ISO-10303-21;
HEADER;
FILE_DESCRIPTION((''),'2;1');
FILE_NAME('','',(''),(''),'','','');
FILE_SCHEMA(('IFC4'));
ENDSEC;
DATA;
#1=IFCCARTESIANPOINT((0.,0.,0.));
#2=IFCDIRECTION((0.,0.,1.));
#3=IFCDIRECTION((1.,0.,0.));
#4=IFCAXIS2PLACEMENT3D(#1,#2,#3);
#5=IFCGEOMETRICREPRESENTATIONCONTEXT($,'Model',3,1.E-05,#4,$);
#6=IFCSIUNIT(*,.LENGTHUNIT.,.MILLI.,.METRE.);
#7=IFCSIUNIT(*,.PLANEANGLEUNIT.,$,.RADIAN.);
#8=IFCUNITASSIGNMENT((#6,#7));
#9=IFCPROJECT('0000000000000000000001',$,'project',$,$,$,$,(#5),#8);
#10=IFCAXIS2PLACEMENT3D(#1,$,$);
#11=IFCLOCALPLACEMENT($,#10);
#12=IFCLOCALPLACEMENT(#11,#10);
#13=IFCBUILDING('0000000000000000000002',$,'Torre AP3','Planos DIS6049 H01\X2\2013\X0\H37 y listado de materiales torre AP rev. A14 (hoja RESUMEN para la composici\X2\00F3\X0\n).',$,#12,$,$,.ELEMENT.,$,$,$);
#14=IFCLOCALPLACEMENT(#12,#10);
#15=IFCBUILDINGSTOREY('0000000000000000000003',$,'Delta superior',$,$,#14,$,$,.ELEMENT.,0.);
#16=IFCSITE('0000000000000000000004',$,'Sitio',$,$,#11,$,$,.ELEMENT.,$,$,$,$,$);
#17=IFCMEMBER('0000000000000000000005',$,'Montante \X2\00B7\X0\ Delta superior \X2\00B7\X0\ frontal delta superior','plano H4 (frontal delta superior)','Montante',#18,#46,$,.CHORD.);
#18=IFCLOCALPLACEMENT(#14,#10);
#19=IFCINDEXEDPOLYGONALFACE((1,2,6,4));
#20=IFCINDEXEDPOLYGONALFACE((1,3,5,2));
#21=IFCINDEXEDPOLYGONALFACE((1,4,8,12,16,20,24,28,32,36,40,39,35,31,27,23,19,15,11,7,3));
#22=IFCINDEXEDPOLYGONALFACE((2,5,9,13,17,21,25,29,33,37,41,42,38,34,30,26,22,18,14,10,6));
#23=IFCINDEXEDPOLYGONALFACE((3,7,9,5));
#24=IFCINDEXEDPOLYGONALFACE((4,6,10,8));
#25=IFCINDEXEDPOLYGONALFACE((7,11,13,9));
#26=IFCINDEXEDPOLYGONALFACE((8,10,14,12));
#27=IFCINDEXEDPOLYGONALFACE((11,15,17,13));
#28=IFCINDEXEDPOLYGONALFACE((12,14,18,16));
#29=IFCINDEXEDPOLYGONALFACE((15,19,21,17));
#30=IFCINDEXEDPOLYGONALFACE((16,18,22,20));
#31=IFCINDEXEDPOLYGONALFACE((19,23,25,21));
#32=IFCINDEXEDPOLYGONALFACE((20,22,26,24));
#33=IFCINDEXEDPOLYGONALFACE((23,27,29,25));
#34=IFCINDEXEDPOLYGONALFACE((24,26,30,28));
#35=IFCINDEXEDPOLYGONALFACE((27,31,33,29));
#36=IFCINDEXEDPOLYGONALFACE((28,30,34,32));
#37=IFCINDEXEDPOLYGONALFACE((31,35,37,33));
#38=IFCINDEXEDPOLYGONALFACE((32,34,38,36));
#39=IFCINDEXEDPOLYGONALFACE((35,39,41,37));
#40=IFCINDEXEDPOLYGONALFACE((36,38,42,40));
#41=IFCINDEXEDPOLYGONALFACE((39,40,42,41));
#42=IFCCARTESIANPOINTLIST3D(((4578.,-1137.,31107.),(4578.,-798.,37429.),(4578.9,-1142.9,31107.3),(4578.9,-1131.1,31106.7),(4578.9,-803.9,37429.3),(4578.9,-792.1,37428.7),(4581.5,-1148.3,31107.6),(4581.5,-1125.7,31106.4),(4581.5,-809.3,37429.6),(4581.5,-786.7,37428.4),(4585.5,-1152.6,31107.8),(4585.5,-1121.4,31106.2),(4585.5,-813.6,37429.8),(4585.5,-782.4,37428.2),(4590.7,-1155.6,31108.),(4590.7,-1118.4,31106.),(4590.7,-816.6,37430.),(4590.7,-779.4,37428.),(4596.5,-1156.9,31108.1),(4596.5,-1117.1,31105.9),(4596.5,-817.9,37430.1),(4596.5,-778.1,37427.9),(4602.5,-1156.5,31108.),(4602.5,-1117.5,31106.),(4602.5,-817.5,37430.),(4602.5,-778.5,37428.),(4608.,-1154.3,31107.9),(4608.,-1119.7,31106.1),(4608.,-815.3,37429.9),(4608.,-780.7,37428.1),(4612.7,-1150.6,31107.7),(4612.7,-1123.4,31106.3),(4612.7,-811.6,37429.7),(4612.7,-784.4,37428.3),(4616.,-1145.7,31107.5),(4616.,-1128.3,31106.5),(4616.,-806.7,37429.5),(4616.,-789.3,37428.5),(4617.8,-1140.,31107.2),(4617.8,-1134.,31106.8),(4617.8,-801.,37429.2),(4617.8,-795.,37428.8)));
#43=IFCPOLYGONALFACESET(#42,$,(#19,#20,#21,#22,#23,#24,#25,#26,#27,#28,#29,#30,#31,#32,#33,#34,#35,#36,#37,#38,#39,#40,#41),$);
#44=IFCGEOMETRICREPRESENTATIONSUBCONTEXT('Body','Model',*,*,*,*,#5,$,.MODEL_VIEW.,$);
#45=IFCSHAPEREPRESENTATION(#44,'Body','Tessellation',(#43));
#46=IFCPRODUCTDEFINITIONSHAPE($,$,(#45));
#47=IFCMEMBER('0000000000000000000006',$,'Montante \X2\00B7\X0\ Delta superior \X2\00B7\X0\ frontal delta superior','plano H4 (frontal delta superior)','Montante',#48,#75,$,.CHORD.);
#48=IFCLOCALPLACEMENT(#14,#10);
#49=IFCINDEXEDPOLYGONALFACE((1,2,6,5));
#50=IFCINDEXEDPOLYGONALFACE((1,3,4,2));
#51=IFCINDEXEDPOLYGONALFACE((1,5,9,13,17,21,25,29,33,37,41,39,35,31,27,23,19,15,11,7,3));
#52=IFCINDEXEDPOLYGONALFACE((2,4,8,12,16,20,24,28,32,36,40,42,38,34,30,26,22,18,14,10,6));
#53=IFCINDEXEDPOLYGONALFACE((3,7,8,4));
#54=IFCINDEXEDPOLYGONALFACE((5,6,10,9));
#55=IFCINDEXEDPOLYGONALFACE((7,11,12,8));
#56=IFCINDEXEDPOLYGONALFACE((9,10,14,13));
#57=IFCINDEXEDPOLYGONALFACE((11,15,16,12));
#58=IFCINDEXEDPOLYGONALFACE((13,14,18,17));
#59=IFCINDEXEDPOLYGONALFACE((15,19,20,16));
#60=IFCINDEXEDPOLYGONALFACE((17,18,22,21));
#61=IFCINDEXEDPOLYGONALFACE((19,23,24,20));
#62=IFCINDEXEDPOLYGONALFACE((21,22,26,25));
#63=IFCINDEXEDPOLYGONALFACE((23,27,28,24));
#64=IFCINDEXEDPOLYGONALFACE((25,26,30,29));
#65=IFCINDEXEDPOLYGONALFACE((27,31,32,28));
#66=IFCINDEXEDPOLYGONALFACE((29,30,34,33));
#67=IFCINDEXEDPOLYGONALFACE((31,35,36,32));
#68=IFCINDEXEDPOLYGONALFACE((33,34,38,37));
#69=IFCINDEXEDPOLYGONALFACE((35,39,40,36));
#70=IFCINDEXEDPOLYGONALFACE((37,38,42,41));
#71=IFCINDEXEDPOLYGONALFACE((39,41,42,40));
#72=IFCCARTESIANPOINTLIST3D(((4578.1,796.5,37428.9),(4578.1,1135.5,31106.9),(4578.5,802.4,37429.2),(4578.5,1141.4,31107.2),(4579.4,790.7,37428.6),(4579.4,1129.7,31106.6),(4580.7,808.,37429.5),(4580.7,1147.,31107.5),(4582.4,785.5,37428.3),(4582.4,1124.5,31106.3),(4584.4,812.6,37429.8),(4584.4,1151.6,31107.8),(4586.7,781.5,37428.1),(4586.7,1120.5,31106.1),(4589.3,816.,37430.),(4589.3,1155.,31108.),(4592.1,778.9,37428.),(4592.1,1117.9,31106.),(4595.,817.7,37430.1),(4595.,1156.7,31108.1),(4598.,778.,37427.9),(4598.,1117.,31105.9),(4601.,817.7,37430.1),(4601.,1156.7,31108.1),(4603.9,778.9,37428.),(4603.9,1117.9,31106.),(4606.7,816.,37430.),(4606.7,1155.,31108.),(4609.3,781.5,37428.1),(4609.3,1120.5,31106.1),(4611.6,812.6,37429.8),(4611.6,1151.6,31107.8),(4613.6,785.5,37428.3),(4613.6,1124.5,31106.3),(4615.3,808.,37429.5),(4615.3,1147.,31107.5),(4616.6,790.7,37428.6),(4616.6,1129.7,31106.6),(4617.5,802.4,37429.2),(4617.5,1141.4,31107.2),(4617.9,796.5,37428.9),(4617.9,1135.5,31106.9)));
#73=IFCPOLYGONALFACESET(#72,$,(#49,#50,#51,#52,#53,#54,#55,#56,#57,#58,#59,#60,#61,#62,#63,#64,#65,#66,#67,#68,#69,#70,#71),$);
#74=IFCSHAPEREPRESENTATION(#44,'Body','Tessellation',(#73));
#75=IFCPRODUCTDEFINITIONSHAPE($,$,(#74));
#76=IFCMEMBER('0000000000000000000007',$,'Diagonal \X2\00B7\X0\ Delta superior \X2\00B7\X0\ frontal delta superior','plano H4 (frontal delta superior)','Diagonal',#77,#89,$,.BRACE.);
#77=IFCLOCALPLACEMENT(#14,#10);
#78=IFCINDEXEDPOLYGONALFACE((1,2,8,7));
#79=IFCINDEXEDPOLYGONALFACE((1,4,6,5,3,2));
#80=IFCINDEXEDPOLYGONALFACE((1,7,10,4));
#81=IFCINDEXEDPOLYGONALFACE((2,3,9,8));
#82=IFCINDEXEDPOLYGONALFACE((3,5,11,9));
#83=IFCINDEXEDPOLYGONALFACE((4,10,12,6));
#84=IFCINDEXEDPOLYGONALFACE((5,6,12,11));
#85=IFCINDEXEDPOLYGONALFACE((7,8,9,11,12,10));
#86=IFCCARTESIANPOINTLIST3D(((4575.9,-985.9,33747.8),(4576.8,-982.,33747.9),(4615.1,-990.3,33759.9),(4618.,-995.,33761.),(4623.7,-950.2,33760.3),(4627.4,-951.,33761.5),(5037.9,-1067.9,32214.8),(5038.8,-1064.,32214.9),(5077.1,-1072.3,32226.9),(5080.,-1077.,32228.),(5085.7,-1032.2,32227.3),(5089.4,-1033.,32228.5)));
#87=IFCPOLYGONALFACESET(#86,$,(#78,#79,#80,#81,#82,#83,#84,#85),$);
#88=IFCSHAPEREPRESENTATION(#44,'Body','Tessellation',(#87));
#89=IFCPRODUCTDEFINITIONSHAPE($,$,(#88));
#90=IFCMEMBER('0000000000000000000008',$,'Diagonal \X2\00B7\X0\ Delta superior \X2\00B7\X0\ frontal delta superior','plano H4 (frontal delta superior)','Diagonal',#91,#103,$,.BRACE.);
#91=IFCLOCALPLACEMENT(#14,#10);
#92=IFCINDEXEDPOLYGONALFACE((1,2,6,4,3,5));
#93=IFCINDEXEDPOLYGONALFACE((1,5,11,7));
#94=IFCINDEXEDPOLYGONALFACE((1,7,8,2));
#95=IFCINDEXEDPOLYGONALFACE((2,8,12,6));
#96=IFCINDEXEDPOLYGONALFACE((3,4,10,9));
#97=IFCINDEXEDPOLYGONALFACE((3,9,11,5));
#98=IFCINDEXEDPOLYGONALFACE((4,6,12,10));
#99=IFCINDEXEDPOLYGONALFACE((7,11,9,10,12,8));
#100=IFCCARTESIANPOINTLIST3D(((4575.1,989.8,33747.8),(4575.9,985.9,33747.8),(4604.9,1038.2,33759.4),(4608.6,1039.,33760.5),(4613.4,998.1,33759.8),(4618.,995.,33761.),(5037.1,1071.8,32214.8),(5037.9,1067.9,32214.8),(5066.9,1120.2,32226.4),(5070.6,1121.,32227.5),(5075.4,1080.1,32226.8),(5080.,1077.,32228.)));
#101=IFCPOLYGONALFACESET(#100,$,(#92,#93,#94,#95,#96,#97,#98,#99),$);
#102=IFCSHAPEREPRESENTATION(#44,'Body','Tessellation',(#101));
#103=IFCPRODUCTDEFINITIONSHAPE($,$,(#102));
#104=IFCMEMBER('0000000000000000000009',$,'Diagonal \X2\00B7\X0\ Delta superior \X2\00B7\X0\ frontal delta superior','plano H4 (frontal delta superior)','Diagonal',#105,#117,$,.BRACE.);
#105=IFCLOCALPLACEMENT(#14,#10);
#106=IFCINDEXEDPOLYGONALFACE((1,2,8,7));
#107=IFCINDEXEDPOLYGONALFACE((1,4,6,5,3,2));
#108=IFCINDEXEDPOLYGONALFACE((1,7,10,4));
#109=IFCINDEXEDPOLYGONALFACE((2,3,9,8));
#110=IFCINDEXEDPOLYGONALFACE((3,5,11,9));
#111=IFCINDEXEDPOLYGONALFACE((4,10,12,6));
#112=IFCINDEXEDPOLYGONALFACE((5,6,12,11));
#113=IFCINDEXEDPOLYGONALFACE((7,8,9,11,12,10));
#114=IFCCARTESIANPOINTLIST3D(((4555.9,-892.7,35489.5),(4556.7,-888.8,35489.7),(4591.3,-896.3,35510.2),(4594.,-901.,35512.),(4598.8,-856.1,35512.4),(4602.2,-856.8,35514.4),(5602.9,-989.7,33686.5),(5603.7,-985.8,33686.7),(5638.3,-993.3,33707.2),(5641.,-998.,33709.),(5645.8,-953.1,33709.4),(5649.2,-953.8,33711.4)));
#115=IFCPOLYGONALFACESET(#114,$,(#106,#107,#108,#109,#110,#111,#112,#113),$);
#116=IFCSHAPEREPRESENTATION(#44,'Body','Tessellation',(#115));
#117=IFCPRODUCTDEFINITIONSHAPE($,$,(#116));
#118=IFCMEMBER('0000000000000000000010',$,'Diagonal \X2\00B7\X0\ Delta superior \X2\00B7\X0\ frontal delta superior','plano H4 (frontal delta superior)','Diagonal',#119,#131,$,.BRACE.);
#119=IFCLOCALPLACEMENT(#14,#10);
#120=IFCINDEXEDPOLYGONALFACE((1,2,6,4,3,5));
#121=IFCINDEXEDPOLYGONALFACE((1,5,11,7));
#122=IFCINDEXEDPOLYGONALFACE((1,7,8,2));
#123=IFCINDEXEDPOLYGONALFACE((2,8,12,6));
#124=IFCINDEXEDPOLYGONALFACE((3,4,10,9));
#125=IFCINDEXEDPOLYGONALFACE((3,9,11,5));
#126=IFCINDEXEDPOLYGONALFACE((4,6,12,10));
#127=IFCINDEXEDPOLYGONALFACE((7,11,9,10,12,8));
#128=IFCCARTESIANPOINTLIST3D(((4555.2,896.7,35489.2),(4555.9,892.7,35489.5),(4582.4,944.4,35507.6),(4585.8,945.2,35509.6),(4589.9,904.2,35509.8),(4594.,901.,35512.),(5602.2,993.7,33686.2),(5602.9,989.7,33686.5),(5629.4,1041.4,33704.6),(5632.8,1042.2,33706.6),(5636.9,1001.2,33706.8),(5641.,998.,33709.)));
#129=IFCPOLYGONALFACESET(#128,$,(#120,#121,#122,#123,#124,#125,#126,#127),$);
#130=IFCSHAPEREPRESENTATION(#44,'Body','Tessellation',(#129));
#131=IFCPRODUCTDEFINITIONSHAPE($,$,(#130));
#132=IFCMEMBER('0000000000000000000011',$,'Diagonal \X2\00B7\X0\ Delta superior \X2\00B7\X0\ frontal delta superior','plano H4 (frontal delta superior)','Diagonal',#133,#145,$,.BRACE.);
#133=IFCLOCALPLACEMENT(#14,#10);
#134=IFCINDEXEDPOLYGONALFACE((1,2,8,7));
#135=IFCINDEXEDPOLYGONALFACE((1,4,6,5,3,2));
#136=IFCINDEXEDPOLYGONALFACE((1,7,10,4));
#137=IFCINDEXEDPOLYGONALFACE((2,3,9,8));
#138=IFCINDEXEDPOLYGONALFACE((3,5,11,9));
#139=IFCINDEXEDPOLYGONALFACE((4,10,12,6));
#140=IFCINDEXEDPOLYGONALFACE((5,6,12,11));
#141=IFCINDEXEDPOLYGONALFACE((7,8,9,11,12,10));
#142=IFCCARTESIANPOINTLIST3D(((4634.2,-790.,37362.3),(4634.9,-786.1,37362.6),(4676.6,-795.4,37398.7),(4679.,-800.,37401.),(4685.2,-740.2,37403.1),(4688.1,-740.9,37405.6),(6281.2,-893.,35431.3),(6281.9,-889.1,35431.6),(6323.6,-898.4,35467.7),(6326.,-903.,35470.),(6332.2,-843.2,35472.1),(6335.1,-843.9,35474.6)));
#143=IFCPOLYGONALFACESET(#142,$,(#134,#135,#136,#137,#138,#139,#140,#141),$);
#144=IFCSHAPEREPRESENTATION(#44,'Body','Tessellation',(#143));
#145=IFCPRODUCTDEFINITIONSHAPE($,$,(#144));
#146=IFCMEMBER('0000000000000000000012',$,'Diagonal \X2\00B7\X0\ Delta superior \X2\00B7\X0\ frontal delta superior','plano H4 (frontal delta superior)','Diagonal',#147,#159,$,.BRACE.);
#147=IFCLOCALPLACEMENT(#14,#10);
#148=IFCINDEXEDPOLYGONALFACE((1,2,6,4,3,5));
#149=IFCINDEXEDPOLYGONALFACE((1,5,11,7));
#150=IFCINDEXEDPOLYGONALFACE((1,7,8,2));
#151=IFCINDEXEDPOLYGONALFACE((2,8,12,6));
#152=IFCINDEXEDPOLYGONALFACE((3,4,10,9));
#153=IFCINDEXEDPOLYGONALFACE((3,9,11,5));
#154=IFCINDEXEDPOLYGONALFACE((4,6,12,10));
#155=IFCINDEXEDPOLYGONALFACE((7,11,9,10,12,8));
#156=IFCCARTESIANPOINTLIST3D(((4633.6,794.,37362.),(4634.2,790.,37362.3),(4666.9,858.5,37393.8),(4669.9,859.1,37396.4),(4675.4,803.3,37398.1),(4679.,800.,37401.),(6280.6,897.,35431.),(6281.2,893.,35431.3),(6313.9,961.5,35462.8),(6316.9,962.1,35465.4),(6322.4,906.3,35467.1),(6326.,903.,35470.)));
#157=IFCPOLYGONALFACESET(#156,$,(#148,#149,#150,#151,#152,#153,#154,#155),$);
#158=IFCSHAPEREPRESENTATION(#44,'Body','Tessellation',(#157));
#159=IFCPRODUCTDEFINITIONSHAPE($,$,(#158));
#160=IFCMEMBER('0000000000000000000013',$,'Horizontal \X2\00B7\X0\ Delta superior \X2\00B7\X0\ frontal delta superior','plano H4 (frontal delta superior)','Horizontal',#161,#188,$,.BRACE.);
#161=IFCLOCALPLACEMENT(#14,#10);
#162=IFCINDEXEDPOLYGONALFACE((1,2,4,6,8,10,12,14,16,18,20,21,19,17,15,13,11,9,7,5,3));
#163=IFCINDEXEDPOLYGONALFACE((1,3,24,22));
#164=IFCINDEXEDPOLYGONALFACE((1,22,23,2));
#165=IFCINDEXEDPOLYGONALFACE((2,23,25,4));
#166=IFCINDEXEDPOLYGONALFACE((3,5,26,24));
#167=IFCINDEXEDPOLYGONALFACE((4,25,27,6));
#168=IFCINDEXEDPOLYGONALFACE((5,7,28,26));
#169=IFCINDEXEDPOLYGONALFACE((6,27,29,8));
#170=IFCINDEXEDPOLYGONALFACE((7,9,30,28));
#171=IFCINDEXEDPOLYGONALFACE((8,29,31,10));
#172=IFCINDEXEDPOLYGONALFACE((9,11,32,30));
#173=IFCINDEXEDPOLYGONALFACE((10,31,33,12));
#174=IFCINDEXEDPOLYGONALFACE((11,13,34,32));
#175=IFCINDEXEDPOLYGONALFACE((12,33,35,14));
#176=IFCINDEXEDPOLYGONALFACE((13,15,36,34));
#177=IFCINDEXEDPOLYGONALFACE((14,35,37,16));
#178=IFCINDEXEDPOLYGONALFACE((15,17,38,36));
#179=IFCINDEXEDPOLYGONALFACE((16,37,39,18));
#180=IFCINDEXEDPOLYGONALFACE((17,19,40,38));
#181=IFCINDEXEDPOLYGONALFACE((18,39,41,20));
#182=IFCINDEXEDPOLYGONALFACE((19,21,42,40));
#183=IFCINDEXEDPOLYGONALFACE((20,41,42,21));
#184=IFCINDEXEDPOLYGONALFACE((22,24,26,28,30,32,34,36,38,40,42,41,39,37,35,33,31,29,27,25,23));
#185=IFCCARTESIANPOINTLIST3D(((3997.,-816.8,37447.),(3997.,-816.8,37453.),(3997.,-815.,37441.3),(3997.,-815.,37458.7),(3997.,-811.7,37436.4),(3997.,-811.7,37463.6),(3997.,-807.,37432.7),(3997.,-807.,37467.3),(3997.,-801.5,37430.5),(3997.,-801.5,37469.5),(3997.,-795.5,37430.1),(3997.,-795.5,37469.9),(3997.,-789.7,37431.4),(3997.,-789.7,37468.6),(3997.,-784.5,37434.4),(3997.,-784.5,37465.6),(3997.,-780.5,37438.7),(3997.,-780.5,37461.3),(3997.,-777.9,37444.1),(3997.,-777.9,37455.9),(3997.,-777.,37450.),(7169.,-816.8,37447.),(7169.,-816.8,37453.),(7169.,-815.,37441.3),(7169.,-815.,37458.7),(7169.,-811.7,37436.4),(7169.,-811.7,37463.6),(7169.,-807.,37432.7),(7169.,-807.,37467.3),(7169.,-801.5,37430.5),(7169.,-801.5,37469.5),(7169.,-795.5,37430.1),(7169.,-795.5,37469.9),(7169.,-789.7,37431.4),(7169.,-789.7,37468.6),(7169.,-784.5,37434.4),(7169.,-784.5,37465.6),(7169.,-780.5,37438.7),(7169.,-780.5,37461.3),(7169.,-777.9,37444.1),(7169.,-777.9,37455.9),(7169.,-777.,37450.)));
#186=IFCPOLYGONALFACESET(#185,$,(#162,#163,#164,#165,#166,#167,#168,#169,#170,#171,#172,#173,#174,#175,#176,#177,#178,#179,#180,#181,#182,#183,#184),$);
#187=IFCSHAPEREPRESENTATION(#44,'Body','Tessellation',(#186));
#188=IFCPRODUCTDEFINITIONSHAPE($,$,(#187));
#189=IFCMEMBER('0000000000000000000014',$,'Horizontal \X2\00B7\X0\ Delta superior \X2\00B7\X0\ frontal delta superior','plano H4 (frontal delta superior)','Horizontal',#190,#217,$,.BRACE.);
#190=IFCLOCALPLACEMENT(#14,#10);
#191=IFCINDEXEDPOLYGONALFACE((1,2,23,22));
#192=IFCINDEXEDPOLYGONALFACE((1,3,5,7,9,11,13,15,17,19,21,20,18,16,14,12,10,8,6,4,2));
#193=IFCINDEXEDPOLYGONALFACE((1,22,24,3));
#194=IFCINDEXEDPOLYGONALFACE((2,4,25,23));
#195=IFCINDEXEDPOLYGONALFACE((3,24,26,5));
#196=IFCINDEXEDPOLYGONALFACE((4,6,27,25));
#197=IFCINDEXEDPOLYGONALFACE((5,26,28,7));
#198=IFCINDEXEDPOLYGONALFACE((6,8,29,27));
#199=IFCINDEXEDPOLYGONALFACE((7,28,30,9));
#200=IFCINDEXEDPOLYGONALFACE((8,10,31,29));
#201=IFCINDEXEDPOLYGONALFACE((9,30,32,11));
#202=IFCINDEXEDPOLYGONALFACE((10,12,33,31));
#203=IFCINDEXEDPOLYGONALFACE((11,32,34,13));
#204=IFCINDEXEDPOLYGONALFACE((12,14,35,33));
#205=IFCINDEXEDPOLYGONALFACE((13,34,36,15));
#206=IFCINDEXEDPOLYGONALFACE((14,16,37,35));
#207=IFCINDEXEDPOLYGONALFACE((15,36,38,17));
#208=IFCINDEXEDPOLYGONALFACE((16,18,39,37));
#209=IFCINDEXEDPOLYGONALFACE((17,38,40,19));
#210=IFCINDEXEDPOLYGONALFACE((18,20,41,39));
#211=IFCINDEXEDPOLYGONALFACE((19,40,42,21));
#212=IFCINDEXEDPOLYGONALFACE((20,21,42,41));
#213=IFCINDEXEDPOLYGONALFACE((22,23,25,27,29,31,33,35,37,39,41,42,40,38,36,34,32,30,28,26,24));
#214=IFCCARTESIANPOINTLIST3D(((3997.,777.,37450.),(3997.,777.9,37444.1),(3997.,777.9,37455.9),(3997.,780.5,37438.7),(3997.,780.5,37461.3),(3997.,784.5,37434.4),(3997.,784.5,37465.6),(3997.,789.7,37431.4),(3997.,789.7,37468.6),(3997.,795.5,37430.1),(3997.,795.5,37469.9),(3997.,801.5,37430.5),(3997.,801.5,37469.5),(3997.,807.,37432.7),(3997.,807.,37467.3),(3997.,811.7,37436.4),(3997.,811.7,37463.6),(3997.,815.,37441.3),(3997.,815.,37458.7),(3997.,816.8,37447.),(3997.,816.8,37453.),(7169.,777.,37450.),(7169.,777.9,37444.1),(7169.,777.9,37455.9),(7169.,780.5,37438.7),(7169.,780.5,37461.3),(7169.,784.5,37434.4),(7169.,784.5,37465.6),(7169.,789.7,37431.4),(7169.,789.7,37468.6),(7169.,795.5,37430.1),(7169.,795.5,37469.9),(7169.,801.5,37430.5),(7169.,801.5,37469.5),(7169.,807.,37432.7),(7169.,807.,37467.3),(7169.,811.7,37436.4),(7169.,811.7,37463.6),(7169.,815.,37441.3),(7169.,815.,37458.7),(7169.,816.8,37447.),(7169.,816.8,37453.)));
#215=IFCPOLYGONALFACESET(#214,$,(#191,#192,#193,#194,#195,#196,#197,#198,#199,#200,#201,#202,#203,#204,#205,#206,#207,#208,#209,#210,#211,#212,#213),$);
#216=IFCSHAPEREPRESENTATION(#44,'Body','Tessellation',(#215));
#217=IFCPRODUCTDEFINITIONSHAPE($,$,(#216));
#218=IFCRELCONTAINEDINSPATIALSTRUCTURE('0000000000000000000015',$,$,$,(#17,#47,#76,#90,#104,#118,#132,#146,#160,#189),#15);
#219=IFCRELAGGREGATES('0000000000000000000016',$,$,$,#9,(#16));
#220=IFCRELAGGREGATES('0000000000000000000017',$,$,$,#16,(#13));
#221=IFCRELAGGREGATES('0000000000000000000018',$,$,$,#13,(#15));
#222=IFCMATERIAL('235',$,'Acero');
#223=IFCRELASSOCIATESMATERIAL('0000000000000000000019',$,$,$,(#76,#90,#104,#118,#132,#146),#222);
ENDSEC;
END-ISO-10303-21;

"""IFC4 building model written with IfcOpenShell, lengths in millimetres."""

from ifc_helpers import new_model, si_unit, frame, frame_2d, origin, origin_with_axes, place, context, subcontext, project, spatial, circle, l_section, extrude, material, element, save


model = new_model("IFC4")

# Units and contexts
model_context = context("Model", 3, precision=1e-05, world=origin_with_axes())
body_context = subcontext(model_context, "Body", "Model", "MODEL_VIEW")
ifc_project = project(units=[si_unit("LENGTHUNIT", "METRE", prefix="MILLI"), si_unit("PLANEANGLEUNIT", "RADIAN")], contexts=[model_context])

# Site, building, storey
site_placement = place(None, origin())
site = spatial("IfcSite", under=ifc_project, at=site_placement, Name="Sitio", CompositionType="ELEMENT")
building_placement = place(site_placement, origin())
building = spatial("IfcBuilding", under=site, at=building_placement, Name="Torre AP3", Description="Planos DIS6049 H01–H37 y listado de materiales torre AP rev. A14 (hoja RESUMEN para la composición).", CompositionType="ELEMENT")
storey_placement = place(building_placement, origin())
storey = spatial("IfcBuildingStorey", under=building, at=storey_placement, Name="Delta superior", CompositionType="ELEMENT", Elevation=0.0)

# Members
for number, where, z_axis, x_axis, name in (
    (1, (4598.0, -798.0, 37429.0), (0.0, -0.053545, -0.998565), (-1.0, 0.0, 0.0), "Montante · Delta superior · frontal delta superior"),
    (2, (4598.0, 798.0, 37429.0), (0.0, 0.053545, -0.998565), (0.0, -0.998565, -0.053545), "Montante · Delta superior · frontal delta superior"),
):
    element("IfcMember", number, at=place(storey_placement, frame(where, z_axis=z_axis, x_axis=x_axis)), inside=storey, Name=name, Description="plano H4 (frontal delta superior)", ObjectType="Montante", PredefinedType="CHORD", context=body_context, shape_type="SweptSolid", body=[
        extrude(circle(Radius=20.0), None, (0.0, 0.0, 1.0), 6331.1),
    ])
ifc_material_1 = material(Name="235", Category="Acero")
for number, where, z_axis, x_axis, name in (
    (3, (4618.0, -995.0, 33761.0), (0.288173, -0.051148, -0.956211), (-0.934509, 0.202848, -0.292483), "Diagonal · Delta superior · frontal delta superior"),
    (4, (4618.0, 995.0, 33761.0), (0.288173, 0.051148, -0.956211), (-0.934509, -0.202848, -0.292483), "Diagonal · Delta superior · frontal delta superior"),
):
    element("IfcMember", number, at=place(storey_placement, frame(where, z_axis=z_axis, x_axis=x_axis)), inside=storey, material=ifc_material_1, Name=name, Description="plano H4 (frontal delta superior)", ObjectType="Diagonal", PredefinedType="BRACE", context=body_context, shape_type="SweptSolid", body=[
        extrude(l_section(Depth=45.0, Width=45.0, Thickness=4.0, at=frame_2d((22.5, 22.5))), None, (0.0, 0.0, 1.0), 1603.2),
    ])
for number, where, z_axis, x_axis, name in (
    (5, (4594.0, -901.0, 35512.0), (0.501628, -0.046474, -0.863834), (-0.845685, 0.183933, -0.500984), "Diagonal · Delta superior · frontal delta superior"),
    (6, (4594.0, 901.0, 35512.0), (0.501628, 0.046474, -0.863834), (-0.845685, -0.183933, -0.500984), "Diagonal · Delta superior · frontal delta superior"),
):
    element("IfcMember", number, at=place(storey_placement, frame(where, z_axis=z_axis, x_axis=x_axis)), inside=storey, material=ifc_material_1, Name=name, Description="plano H4 (frontal delta superior)", ObjectType="Diagonal", PredefinedType="BRACE", context=body_context, shape_type="SweptSolid", body=[
        extrude(l_section(Depth=45.0, Width=45.0, Thickness=4.0, at=frame_2d((22.5, 22.5))), None, (0.0, 0.0, 1.0), 2087.2),
    ])
for number, where, z_axis, x_axis, name in (
    (7, (4679.0, -800.0, 37401.0), (0.648406, -0.04055, -0.760214), (-0.745871, 0.166153, -0.645035), "Diagonal · Delta superior · frontal delta superior"),
    (8, (4679.0, 800.0, 37401.0), (0.648406, 0.04055, -0.760214), (-0.745871, -0.166153, -0.645035), "Diagonal · Delta superior · frontal delta superior"),
):
    element("IfcMember", number, at=place(storey_placement, frame(where, z_axis=z_axis, x_axis=x_axis)), inside=storey, material=ifc_material_1, Name=name, Description="plano H4 (frontal delta superior)", ObjectType="Diagonal", PredefinedType="BRACE", context=body_context, shape_type="SweptSolid", body=[
        extrude(l_section(Depth=60.0, Width=60.0, Thickness=4.0, at=frame_2d((30.0, 30.0))), None, (0.0, 0.0, 1.0), 2540.1),
    ])
for number, where, z_axis, x_axis, name in (
    (9, (3997.0, -797.0, 37450.0), (1.0, 0.0, 0.0), (0.0, 1.0, 0.0), "Horizontal · Delta superior · frontal delta superior"),
    (10, (3997.0, 797.0, 37450.0), (1.0, 0.0, 0.0), (0.0, -1.0, 0.0), "Horizontal · Delta superior · frontal delta superior"),
):
    element("IfcMember", number, at=place(storey_placement, frame(where, z_axis=z_axis, x_axis=x_axis)), inside=storey, Name=name, Description="plano H4 (frontal delta superior)", ObjectType="Horizontal", PredefinedType="BRACE", context=body_context, shape_type="SweptSolid", body=[
        extrude(circle(Radius=20.0), None, (0.0, 0.0, 1.0), 3172.0),
    ])

save(model, "model.ifc")
